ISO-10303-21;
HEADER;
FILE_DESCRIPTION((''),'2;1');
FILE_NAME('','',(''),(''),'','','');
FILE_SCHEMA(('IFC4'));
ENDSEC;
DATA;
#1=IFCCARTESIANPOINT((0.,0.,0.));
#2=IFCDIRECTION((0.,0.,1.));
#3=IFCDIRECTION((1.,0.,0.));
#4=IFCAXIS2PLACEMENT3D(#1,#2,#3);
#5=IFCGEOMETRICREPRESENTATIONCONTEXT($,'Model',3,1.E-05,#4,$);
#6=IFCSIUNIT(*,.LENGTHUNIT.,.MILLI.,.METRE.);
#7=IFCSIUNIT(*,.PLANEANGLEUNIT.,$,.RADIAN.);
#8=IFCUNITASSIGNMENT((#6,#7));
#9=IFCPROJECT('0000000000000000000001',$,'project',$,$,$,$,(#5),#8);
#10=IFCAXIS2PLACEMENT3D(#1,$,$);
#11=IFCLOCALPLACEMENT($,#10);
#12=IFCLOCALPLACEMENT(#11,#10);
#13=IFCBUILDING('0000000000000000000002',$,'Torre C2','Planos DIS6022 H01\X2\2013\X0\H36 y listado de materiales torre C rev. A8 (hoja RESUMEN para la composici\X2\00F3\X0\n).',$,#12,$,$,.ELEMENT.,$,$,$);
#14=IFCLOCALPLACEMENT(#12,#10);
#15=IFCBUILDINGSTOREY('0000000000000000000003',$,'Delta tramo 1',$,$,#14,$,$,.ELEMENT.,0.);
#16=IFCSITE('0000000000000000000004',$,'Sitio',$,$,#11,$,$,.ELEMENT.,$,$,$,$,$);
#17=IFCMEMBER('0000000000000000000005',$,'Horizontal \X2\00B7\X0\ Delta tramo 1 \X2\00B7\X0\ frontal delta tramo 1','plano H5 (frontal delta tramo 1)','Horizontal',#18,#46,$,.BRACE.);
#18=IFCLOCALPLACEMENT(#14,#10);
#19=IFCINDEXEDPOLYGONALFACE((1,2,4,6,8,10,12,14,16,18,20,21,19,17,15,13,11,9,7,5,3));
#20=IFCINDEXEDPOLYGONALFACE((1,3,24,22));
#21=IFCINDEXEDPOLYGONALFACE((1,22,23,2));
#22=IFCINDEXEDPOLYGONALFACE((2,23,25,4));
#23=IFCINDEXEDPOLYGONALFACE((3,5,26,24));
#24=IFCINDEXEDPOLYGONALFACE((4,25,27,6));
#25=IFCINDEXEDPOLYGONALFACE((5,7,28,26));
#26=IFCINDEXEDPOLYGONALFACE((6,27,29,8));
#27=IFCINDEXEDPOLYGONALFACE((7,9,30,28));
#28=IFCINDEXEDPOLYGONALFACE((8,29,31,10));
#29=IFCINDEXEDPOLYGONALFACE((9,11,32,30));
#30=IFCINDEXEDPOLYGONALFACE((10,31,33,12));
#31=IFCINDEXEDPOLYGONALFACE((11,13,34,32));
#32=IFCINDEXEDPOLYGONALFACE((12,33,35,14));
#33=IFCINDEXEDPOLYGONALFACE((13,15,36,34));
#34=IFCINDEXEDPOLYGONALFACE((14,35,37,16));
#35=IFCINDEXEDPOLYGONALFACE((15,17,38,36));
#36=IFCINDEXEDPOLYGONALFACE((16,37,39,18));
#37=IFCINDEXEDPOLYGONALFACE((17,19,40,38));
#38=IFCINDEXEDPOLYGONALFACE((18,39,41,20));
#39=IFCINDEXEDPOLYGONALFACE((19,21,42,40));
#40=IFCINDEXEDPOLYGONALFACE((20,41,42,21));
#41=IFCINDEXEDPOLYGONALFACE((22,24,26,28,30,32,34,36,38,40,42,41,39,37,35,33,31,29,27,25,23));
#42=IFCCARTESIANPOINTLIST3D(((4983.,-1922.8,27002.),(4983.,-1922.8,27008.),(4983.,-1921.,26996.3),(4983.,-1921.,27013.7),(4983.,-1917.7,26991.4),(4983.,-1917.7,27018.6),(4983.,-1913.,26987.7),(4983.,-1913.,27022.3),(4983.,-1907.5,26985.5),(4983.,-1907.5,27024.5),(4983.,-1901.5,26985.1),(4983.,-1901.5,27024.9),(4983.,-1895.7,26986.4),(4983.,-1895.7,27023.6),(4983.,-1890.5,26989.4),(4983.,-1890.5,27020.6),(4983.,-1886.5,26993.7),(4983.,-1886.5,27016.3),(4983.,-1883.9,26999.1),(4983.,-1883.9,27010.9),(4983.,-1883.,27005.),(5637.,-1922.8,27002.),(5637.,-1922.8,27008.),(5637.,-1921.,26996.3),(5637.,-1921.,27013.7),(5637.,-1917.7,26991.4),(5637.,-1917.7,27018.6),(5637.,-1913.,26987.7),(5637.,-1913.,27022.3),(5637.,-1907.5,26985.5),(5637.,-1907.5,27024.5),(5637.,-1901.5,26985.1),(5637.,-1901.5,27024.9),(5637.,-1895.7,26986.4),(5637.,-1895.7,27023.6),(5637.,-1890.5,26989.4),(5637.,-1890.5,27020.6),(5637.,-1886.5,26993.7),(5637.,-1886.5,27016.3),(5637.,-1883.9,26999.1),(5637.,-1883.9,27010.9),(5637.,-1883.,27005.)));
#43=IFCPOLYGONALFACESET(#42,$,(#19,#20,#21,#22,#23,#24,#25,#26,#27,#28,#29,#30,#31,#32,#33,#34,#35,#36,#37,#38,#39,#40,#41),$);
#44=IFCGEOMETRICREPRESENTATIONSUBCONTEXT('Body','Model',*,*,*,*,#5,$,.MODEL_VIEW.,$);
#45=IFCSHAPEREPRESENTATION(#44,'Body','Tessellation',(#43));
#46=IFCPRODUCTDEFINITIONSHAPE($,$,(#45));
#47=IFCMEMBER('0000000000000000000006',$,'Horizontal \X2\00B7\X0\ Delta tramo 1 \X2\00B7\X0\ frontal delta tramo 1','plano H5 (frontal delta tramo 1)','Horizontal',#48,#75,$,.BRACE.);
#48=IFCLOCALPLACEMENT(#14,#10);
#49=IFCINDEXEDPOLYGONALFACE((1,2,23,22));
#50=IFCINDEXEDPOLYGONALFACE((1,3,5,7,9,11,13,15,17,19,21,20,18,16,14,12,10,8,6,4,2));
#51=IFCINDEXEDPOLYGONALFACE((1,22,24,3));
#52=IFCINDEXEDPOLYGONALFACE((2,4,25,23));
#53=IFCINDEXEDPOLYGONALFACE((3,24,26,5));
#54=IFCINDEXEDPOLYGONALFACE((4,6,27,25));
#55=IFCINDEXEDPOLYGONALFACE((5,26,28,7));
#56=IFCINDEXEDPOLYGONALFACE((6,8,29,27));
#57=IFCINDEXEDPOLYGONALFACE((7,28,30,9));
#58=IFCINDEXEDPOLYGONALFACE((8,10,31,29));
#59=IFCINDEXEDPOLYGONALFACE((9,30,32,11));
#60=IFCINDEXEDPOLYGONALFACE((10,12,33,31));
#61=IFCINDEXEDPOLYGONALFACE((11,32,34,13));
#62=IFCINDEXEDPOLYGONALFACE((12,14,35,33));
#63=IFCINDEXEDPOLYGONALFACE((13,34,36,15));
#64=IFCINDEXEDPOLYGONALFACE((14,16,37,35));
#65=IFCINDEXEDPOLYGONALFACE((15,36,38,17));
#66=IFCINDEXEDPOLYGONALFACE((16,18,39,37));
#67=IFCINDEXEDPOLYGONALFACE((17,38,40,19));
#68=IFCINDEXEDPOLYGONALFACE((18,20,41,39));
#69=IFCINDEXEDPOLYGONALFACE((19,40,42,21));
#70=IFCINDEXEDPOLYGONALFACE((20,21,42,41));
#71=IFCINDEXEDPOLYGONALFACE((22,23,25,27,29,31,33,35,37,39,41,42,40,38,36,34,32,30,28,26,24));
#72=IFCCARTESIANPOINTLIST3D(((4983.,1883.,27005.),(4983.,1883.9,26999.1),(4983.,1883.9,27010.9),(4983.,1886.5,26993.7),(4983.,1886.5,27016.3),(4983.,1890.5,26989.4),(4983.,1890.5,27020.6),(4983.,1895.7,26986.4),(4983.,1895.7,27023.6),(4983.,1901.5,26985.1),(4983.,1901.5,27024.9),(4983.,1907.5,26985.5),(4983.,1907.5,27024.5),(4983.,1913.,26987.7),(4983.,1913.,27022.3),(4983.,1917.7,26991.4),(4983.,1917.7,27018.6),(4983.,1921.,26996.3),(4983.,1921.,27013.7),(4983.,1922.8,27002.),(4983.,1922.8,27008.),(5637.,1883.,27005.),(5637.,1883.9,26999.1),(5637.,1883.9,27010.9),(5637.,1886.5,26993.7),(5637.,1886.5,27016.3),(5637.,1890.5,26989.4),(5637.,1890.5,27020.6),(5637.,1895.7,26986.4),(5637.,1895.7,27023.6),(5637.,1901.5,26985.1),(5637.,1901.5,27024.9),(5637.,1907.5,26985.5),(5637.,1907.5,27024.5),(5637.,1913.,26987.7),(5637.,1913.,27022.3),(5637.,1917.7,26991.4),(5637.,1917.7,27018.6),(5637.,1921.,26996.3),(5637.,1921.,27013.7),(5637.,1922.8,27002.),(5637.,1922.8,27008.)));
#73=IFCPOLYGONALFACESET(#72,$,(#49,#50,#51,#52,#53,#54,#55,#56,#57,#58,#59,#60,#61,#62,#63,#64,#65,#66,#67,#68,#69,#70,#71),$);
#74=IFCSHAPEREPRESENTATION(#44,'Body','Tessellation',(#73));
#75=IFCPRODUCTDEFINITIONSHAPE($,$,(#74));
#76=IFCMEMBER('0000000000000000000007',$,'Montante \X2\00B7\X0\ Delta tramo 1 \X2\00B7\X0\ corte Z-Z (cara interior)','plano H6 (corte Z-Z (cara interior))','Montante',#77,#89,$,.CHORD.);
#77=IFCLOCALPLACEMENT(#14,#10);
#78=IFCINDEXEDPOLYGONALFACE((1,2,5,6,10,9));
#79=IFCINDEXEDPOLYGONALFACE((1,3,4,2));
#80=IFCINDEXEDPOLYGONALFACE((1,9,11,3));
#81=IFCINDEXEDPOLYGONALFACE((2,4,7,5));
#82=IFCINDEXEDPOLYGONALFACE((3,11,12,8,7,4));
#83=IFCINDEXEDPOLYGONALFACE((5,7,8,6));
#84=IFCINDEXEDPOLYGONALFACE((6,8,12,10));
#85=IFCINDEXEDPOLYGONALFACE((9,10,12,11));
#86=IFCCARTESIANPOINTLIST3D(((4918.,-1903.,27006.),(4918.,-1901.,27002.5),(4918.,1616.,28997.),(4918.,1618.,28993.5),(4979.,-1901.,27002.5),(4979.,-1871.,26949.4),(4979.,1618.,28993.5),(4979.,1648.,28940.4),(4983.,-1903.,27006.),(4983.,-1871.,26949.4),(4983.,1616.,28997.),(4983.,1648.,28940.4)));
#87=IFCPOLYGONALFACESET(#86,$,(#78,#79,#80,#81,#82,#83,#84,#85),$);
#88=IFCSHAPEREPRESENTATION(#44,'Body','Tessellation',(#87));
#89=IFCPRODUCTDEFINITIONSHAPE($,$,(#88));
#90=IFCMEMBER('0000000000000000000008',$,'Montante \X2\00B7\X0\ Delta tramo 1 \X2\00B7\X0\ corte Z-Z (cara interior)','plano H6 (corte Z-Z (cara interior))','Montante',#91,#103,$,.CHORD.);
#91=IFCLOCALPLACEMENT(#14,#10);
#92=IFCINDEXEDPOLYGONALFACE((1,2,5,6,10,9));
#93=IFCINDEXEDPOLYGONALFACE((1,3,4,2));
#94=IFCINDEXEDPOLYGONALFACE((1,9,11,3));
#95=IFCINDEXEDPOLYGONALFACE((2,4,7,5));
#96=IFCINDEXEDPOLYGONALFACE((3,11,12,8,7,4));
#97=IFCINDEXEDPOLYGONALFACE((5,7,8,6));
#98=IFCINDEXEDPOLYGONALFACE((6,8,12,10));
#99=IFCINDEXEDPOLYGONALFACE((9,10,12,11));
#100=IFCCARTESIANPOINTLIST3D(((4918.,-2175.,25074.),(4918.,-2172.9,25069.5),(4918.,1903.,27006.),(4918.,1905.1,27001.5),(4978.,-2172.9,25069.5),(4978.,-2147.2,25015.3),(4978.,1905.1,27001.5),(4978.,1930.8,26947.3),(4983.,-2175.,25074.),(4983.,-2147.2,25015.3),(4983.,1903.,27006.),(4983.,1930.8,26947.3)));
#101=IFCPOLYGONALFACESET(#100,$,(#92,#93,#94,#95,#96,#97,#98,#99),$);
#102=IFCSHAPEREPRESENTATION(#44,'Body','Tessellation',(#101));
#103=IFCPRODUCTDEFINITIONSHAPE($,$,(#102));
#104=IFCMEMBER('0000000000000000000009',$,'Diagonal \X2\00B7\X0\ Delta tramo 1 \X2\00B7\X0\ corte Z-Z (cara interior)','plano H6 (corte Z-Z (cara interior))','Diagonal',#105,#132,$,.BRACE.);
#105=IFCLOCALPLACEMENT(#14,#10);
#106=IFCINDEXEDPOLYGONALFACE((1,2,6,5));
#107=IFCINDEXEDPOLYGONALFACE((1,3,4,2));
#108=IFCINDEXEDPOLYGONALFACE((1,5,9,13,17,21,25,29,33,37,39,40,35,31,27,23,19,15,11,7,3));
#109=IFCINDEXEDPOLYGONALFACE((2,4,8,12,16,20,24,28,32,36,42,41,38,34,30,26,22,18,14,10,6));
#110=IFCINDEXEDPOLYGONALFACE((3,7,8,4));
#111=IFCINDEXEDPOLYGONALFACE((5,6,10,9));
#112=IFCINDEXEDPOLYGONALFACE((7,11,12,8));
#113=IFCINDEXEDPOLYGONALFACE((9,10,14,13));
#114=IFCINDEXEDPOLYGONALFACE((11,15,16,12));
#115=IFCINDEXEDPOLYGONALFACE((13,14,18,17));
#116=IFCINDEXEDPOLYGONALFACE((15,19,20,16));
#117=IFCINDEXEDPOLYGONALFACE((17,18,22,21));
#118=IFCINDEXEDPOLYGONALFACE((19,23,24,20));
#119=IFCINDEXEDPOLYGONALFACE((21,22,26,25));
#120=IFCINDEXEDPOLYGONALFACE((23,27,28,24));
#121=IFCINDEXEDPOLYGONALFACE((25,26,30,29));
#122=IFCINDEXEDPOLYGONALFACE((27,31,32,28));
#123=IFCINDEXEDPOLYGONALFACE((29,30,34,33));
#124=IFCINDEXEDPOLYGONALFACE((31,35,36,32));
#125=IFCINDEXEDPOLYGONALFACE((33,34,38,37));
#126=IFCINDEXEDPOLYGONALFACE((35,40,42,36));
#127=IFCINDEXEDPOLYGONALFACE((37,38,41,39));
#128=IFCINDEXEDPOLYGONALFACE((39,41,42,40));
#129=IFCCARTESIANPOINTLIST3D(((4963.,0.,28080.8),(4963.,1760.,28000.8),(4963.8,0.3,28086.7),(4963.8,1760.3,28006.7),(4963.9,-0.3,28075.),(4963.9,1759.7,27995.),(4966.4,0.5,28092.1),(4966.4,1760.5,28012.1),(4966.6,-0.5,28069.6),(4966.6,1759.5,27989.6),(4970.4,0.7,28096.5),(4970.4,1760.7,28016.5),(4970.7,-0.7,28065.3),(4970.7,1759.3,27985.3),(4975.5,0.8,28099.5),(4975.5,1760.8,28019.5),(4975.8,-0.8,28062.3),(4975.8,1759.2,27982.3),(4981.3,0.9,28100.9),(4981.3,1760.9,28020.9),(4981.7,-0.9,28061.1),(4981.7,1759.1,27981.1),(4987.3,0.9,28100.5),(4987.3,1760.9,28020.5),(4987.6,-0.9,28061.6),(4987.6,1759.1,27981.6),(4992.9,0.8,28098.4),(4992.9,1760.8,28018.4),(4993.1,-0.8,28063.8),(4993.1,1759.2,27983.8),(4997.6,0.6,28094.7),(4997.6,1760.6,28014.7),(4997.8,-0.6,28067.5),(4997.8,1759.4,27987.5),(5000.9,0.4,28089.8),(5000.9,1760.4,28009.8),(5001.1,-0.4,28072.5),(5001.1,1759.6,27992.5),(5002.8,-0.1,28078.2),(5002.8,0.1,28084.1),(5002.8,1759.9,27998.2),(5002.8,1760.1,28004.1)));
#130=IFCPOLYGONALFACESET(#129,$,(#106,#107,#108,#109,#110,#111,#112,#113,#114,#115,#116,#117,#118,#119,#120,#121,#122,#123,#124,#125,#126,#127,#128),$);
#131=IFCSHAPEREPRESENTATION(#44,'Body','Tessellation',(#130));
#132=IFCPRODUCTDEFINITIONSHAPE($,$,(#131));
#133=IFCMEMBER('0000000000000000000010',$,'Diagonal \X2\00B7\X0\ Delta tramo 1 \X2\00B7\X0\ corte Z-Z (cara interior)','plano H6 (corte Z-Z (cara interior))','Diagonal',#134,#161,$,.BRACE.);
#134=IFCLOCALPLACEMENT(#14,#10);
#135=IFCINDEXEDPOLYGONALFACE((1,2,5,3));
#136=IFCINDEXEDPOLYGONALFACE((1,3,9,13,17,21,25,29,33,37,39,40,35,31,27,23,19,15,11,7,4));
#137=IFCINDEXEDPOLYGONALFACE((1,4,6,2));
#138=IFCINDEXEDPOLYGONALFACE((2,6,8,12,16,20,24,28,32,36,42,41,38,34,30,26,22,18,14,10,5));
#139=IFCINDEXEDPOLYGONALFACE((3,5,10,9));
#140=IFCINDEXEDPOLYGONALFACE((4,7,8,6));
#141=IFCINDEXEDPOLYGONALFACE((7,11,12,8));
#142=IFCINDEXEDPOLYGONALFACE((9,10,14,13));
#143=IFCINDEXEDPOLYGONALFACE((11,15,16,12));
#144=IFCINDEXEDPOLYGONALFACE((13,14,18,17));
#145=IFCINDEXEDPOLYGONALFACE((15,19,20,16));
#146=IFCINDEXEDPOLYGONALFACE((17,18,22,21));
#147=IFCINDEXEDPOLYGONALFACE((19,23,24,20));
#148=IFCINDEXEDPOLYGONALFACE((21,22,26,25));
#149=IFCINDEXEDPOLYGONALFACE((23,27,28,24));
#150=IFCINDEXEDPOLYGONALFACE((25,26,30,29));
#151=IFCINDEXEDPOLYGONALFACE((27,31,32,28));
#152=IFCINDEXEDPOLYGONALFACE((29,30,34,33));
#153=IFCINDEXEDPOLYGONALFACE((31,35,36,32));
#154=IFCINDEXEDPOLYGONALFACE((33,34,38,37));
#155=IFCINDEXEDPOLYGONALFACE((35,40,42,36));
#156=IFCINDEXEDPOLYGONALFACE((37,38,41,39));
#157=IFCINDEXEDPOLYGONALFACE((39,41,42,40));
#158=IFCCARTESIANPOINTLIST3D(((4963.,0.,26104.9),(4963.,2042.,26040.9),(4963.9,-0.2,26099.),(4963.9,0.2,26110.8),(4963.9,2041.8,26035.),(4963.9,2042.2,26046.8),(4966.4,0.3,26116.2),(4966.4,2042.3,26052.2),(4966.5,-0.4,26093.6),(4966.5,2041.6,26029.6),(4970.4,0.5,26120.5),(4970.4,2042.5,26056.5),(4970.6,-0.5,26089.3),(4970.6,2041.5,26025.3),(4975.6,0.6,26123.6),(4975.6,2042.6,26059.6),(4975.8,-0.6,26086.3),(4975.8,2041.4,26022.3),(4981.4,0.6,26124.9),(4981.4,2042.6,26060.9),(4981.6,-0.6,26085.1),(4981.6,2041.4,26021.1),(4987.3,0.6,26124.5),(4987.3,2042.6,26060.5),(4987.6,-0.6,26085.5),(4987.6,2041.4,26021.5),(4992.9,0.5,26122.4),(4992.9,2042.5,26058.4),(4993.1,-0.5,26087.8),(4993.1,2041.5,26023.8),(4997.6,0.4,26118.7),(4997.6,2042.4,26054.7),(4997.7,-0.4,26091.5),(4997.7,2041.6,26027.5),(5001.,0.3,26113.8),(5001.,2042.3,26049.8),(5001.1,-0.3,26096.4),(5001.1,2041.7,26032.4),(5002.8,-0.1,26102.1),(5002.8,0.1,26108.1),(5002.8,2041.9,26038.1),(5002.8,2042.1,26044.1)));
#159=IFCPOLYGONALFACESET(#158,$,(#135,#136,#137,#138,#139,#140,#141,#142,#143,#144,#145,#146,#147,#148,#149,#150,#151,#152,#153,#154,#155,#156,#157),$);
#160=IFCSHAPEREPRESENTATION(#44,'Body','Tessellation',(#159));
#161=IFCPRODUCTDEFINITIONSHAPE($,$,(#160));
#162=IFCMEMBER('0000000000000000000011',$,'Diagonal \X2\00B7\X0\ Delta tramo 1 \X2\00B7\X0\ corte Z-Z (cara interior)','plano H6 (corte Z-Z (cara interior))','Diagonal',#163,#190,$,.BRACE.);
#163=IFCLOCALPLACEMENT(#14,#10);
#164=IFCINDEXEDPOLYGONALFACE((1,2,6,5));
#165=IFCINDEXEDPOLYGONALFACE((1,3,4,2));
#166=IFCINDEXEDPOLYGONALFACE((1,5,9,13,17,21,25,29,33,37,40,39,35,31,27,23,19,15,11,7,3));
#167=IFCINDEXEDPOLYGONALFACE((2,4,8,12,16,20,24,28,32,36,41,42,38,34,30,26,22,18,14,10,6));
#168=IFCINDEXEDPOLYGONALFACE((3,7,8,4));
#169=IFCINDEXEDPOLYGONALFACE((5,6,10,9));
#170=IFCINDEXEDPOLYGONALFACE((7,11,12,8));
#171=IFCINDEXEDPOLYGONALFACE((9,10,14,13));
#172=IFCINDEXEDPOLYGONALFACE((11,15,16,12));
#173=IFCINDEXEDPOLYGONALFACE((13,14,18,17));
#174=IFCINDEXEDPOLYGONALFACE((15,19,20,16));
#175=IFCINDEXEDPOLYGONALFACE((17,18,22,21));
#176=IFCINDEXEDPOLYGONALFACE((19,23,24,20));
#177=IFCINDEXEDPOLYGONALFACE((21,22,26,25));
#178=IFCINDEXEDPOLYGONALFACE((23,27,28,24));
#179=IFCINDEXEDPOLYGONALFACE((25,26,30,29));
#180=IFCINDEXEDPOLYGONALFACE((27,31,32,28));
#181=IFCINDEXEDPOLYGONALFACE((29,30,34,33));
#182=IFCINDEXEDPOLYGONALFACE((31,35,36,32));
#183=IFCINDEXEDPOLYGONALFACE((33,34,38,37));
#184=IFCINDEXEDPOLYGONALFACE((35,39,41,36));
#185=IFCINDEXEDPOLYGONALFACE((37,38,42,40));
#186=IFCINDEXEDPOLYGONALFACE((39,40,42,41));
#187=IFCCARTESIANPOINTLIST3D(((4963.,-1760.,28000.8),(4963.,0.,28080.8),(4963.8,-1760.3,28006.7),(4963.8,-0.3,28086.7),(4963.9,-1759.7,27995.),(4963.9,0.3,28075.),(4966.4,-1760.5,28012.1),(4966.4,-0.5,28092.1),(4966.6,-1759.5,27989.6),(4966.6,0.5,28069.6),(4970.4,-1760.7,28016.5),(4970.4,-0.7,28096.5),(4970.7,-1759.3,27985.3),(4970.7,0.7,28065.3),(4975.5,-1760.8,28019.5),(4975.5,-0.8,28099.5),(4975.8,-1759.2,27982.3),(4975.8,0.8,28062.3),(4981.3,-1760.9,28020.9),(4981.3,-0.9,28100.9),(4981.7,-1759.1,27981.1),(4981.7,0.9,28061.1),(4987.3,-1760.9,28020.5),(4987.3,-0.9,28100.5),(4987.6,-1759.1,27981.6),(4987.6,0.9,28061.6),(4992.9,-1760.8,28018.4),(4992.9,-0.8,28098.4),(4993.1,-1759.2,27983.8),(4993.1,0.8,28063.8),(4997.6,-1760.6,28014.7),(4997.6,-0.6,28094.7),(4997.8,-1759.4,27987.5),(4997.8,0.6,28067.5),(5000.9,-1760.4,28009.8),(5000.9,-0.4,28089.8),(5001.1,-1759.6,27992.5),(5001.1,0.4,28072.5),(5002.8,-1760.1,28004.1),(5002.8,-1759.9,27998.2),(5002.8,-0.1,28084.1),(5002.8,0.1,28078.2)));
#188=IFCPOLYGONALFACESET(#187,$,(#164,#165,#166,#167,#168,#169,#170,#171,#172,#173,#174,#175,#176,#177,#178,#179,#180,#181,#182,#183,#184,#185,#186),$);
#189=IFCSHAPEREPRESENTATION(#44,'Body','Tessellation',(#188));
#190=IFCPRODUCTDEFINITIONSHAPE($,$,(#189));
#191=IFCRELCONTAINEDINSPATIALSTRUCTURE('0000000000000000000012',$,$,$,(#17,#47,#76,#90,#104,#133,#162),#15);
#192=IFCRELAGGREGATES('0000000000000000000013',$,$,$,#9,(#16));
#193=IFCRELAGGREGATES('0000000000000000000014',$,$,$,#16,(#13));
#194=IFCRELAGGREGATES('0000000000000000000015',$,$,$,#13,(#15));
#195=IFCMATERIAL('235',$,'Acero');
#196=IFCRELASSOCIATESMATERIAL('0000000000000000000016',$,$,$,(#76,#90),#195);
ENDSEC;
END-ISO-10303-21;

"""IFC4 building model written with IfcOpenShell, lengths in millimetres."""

from ifc_helpers import new_model, si_unit, frame, frame_2d, origin, origin_with_axes, place, context, subcontext, project, spatial, circle, l_section, extrude, material, element, save


model = new_model("IFC4")

# Units and contexts
model_context = context("Model", 3, precision=1e-05, world=origin_with_axes())
body_context = subcontext(model_context, "Body", "Model", "MODEL_VIEW")
ifc_project = project(units=[si_unit("LENGTHUNIT", "METRE", prefix="MILLI"), si_unit("PLANEANGLEUNIT", "RADIAN")], contexts=[model_context])

# Site, building, storey
site_placement = place(None, origin())
site = spatial("IfcSite", under=ifc_project, at=site_placement, Name="Sitio", CompositionType="ELEMENT")
building_placement = place(site_placement, origin())
building = spatial("IfcBuilding", under=site, at=building_placement, Name="Torre C2", Description="Planos DIS6022 H01–H36 y listado de materiales torre C rev. A8 (hoja RESUMEN para la composición).", CompositionType="ELEMENT")
storey_placement = place(building_placement, origin())
storey = spatial("IfcBuildingStorey", under=building, at=storey_placement, Name="Delta tramo 1", CompositionType="ELEMENT", Elevation=0.0)

# Members
for number, where, z_axis, x_axis, name in (
    (1, (5637.0, -1903.0, 27005.0), (-1.0, 0.0, 0.0), (0.0, 1.0, 0.0), "Horizontal · Delta tramo 1 · frontal delta tramo 1"),
    (2, (5637.0, 1903.0, 27005.0), (-1.0, 0.0, 0.0), (0.0, -1.0, 0.0), "Horizontal · Delta tramo 1 · frontal delta tramo 1"),
):
    element("IfcMember", number, at=place(storey_placement, frame(where, z_axis=z_axis, x_axis=x_axis)), inside=storey, Name=name, Description="plano H5 (frontal delta tramo 1)", ObjectType="Horizontal", PredefinedType="BRACE", context=body_context, shape_type="SweptSolid", body=[
        extrude(circle(Radius=20.0), None, (0.0, 0.0, 1.0), 654.0),
    ])
ifc_material_1 = material(Name="235", Category="Acero")
member_1_placement = place(storey_placement, frame((4983.0, -1903.0, 27006.0), z_axis=(0.0, 0.870351, 0.492432), x_axis=(0.0, 0.492432, -0.870351)))
element("IfcMember", 3, at=member_1_placement, inside=storey, material=ifc_material_1, Name="Montante · Delta tramo 1 · corte Z-Z (cara interior)", Description="plano H6 (corte Z-Z (cara interior))", ObjectType="Montante", PredefinedType="CHORD", context=body_context, shape_type="SweptSolid", body=[
    extrude(l_section(Depth=65.0, Width=65.0, Thickness=4.0, at=frame_2d((32.5, 32.5))), None, (0.0, 0.0, 1.0), 4043.2),
])
member_2_placement = place(storey_placement, frame((4983.0, 1903.0, 27006.0), z_axis=(0.0, -0.903711, -0.428144), x_axis=(-1.0, 0.0, 0.0)))
element("IfcMember", 4, at=member_2_placement, inside=storey, material=ifc_material_1, Name="Montante · Delta tramo 1 · corte Z-Z (cara interior)", Description="plano H6 (corte Z-Z (cara interior))", ObjectType="Montante", PredefinedType="CHORD", context=body_context, shape_type="SweptSolid", body=[
    extrude(l_section(Depth=65.0, Width=65.0, Thickness=5.0, at=frame_2d((32.5, 32.5))), None, (0.0, 0.0, 1.0), 4512.5),
])
member_3_placement = place(storey_placement, frame((4983.0, 1760.0, 28001.0), z_axis=(0.0, -0.998969, 0.045408), x_axis=(-0.999968, -0.000364, -0.00801)))
element("IfcMember", 5, at=member_3_placement, inside=storey, Name="Diagonal · Delta tramo 1 · corte Z-Z (cara interior)", Description="plano H6 (corte Z-Z (cara interior))", ObjectType="Diagonal", PredefinedType="BRACE", context=body_context, shape_type="SweptSolid", body=[
    extrude(circle(Radius=20.0), None, (0.0, 0.0, 1.0), 1761.8),
])
member_4_placement = place(storey_placement, frame((4983.0, 2042.0, 26041.0), z_axis=(0.0, -0.999509, 0.031326), x_axis=(-0.999979, -0.000201, -0.006415)))
element("IfcMember", 6, at=member_4_placement, inside=storey, Name="Diagonal · Delta tramo 1 · corte Z-Z (cara interior)", Description="plano H6 (corte Z-Z (cara interior))", ObjectType="Diagonal", PredefinedType="BRACE", context=body_context, shape_type="SweptSolid", body=[
    extrude(circle(Radius=20.0), None, (0.0, 0.0, 1.0), 2043.0),
])
member_5_placement = place(storey_placement, frame((4983.0, -1760.0, 28001.0), z_axis=(0.0, 0.998969, 0.045408), x_axis=(-0.999968, 0.000364, -0.00801)))
element("IfcMember", 7, at=member_5_placement, inside=storey, Name="Diagonal · Delta tramo 1 · corte Z-Z (cara interior)", Description="plano H6 (corte Z-Z (cara interior))", ObjectType="Diagonal", PredefinedType="BRACE", context=body_context, shape_type="SweptSolid", body=[
    extrude(circle(Radius=20.0), None, (0.0, 0.0, 1.0), 1761.8),
])

save(model, "model.ifc")
